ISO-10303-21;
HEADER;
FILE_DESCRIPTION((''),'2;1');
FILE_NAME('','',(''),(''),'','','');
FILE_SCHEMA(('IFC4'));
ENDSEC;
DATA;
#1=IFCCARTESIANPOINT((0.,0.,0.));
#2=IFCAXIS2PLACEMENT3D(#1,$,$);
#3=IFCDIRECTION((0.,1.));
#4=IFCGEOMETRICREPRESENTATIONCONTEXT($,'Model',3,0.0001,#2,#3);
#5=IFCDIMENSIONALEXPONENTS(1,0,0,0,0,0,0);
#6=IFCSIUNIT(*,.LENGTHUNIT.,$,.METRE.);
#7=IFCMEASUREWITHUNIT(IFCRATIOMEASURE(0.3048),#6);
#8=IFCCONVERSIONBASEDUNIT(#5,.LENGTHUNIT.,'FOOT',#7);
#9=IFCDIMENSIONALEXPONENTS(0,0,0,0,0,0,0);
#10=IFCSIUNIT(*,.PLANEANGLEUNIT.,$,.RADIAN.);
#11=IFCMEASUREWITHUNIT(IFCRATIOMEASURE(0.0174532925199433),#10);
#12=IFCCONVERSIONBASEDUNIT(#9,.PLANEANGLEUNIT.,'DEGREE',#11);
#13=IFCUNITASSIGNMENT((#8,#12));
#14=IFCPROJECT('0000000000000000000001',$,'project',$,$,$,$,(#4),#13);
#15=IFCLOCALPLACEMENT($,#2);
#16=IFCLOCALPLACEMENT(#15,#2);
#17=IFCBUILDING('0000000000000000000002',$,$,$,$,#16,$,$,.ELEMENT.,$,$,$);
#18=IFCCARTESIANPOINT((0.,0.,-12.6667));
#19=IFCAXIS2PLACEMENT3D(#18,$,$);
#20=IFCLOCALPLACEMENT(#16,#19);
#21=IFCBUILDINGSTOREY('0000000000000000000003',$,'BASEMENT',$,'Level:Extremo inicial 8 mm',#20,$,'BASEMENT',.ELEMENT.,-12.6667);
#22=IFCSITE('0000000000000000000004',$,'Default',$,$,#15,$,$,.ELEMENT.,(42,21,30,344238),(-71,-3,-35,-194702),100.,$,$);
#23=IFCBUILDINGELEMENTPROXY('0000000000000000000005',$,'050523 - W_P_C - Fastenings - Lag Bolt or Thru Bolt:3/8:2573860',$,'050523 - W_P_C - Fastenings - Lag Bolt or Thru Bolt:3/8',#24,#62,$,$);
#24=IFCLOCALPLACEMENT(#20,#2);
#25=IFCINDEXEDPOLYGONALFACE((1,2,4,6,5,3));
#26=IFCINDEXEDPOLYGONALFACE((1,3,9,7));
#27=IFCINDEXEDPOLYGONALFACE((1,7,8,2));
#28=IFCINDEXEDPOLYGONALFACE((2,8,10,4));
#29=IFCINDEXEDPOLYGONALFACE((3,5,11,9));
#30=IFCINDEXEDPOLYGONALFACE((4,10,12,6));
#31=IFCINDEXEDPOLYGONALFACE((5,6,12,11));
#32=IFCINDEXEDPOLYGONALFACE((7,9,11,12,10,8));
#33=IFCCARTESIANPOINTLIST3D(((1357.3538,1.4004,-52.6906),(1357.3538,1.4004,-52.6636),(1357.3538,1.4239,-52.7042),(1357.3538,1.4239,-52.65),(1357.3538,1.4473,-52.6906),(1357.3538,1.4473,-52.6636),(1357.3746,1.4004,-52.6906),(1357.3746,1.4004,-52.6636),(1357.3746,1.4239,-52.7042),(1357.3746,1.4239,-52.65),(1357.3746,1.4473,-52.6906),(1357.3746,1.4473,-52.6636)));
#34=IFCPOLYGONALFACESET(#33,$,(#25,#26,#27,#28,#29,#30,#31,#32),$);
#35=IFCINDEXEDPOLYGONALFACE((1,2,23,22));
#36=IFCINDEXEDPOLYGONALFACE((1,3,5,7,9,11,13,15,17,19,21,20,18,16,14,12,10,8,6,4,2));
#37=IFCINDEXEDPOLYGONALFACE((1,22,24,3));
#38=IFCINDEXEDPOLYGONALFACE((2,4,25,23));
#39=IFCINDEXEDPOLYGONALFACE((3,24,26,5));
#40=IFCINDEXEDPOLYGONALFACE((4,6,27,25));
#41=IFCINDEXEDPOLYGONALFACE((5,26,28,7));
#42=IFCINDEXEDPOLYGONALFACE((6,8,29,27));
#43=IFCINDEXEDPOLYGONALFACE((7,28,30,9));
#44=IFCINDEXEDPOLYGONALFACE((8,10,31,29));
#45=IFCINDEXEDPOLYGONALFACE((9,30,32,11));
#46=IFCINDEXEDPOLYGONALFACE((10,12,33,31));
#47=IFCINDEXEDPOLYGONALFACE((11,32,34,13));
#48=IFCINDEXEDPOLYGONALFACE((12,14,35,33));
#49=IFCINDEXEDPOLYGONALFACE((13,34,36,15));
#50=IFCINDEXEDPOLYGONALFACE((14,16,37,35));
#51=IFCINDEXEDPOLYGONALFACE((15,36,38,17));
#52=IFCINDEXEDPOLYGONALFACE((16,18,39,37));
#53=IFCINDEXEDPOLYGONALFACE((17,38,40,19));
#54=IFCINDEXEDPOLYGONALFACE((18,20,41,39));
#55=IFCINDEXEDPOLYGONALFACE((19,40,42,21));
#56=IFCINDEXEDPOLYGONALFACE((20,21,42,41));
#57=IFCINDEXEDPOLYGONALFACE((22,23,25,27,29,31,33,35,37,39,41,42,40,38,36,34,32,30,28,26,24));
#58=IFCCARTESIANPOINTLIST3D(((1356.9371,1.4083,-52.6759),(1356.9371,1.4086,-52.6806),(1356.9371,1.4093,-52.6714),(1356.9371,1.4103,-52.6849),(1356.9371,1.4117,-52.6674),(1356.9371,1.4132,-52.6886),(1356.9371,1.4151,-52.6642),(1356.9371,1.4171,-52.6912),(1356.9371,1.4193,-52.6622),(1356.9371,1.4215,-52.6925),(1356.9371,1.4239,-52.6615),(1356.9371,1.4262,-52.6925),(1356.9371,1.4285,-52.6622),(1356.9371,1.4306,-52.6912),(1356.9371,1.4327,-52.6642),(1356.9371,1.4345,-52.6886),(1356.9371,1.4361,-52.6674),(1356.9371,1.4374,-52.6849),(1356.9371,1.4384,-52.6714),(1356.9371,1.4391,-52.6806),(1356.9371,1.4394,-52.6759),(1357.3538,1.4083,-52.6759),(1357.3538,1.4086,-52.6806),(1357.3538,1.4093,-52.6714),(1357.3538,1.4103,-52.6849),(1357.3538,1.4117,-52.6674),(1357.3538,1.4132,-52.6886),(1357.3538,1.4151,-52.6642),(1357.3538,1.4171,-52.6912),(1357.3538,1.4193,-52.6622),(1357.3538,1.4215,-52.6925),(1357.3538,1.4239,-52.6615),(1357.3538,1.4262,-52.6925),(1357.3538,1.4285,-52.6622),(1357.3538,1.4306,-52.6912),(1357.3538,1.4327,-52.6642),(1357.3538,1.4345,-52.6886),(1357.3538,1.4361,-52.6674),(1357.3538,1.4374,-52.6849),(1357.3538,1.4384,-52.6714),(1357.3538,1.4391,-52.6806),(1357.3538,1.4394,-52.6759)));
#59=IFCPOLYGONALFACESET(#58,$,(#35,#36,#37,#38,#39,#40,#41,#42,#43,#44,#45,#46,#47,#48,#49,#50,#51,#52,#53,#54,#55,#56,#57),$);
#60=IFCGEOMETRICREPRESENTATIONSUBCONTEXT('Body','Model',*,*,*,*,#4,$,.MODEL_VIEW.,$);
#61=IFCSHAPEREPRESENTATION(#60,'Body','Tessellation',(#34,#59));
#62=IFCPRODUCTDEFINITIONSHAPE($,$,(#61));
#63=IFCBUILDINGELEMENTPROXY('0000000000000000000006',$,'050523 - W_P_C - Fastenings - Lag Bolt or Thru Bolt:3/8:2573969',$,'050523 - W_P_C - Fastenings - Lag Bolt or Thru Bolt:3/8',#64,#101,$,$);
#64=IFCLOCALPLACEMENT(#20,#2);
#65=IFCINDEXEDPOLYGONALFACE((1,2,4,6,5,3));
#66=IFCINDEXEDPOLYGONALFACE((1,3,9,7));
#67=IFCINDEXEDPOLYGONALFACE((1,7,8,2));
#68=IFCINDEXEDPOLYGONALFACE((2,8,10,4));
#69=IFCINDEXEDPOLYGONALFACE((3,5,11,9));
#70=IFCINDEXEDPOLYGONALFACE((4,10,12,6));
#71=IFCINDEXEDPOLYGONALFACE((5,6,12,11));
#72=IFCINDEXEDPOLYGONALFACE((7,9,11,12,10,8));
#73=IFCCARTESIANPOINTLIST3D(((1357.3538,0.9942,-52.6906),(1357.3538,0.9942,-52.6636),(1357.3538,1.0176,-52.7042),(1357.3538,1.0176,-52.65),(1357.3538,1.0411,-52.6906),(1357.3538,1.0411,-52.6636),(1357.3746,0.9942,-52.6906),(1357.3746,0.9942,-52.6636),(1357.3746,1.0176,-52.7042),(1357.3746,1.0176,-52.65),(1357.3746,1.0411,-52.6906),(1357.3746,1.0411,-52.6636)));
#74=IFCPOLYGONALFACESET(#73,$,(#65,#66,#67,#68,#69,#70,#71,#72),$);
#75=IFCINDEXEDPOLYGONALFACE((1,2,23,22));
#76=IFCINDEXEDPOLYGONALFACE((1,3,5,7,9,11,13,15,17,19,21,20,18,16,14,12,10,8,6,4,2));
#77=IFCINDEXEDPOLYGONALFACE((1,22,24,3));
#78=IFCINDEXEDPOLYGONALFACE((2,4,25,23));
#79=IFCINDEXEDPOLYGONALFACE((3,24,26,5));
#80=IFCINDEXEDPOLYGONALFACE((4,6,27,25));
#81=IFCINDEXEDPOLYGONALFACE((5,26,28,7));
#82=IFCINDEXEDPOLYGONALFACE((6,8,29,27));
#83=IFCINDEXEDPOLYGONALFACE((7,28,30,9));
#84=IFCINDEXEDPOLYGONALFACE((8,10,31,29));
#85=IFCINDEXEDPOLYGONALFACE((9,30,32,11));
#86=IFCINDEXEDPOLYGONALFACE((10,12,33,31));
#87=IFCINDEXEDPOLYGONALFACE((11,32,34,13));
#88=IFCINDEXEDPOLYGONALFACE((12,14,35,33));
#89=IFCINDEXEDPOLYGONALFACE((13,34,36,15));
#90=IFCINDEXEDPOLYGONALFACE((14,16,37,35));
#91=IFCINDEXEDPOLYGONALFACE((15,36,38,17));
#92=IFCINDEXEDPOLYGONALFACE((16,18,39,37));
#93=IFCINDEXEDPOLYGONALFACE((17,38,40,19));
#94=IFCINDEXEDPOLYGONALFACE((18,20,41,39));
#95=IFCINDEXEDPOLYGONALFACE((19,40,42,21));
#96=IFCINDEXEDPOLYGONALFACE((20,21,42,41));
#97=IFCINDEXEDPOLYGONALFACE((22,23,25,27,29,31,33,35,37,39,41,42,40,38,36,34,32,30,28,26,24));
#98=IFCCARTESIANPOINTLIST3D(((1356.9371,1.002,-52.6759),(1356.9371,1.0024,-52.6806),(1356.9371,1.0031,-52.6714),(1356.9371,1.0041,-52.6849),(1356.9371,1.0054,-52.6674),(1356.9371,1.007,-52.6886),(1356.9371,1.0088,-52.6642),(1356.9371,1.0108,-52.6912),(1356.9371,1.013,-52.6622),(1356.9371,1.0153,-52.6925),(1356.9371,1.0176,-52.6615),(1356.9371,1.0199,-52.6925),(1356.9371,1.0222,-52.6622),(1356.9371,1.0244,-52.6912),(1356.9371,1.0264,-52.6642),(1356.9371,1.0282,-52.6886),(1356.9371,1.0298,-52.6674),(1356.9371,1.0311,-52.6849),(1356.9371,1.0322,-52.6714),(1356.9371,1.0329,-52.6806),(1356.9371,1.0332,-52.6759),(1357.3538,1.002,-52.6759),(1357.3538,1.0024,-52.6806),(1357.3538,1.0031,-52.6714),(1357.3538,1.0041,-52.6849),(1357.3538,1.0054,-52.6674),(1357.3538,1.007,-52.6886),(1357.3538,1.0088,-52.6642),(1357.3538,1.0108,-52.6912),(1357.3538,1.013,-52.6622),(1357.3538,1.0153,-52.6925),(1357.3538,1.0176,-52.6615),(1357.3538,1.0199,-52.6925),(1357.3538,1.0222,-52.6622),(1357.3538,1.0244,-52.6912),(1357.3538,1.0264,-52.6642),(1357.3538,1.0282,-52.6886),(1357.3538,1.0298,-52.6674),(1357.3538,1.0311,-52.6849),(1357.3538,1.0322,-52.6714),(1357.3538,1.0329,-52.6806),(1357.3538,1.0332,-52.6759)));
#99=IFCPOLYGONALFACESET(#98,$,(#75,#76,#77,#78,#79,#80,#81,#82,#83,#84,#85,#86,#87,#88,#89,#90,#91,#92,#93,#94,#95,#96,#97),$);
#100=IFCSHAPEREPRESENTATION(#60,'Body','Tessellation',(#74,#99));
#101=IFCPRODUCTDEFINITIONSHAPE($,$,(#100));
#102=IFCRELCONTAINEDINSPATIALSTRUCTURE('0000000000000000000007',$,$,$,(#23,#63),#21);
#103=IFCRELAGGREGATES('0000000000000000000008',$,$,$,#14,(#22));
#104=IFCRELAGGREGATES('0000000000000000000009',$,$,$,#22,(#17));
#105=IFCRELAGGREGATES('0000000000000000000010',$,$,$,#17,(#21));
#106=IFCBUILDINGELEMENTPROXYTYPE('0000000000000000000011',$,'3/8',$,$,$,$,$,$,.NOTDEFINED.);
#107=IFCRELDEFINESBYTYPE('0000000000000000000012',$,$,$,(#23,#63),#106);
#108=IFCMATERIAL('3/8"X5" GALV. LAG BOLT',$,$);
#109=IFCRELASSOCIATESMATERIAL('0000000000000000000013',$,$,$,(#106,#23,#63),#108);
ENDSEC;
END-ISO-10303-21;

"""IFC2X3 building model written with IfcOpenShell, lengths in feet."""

from ifc_helpers import new_model, entity, si_unit, converted_unit, direction, frame, frame_2d, origin, place, context, subcontext, project, spatial, polyline, circle, outline, extrude, source, transform, mapped, material, type_object, type_shapes, element, save


model = new_model("IFC2X3")

# Units and contexts
model_context = context("Model", 3, precision=0.0001, world=origin(), true_north=direction((0.0, 1.0)))
body_context = subcontext(model_context, "Body", "Model", "MODEL_VIEW")
ifc_project = project(units=[converted_unit("LENGTHUNIT", "FOOT", entity("IfcRatioMeasure", 0.3048), si_unit("LENGTHUNIT", "METRE"), dimensions=[1, 0, 0, 0, 0, 0, 0]), converted_unit("PLANEANGLEUNIT", "DEGREE", entity("IfcRatioMeasure", 0.0174532925199433), si_unit("PLANEANGLEUNIT", "RADIAN"), dimensions=[0, 0, 0, 0, 0, 0, 0])], contexts=[model_context])

# Site, building, storey
site_placement = place(None, origin())
site = spatial("IfcSite", under=ifc_project, at=site_placement, Name="Default", CompositionType="ELEMENT", RefLatitude=(42, 21, 30, 344238), RefLongitude=(-71, -3, -35, -194702), RefElevation=100.0)
building_placement = place(site_placement, origin())
building = spatial("IfcBuilding", under=site, at=building_placement, CompositionType="ELEMENT")
storey_placement = place(building_placement, frame((0.0, 0.0, -12.6667)))
storey = spatial("IfcBuildingStorey", under=building, at=storey_placement, Name="BASEMENT", ObjectType="Level:Extremo inicial 8 mm", LongName="BASEMENT", CompositionType="ELEMENT", Elevation=-12.6667)

# Building element proxies
ifc_material_1 = material(Name="3/8\"X5\" GALV. LAG BOLT")
building_element_proxy_type = type_object("IfcBuildingElementProxyType", Name="3/8", PredefinedType="NOTDEFINED", material=ifc_material_1)
shared_shape = source(origin(), body_context, "Body", "SweptSolid", [
    extrude(outline(polyline([(-0.0135, -0.0234), (0.0135, -0.0234), (0.0271, 0.0), (0.0135, 0.0234), (-0.0135, 0.0234), (-0.0271, 0.0), (-0.0135, -0.0234)])), frame((0.0, 0.0, 0.0), z_axis=(0.0, 0.0, 1.0), x_axis=(0.0, -1.0, 0.0)), (0.0, 0.0, 1.0), 0.0208),
    extrude(circle(Radius=0.0156, at=frame_2d((0.0, 0.0), x_axis=(1.0, 0.0))), frame((0.0, 0.0, -0.4167), z_axis=(0.0, 0.0, 1.0), x_axis=(0.0, 1.0, 0.0)), (0.0, 0.0, 1.0), 0.4167),
])
type_shapes(building_element_proxy_type, [shared_shape])
for number, where, z_axis, x_axis, name in (
    (1, (1357.3538, 1.4239, -52.6771), (1.0, 0.0, 0.0), (0.0, 1.0, 0.0), "050523 - W_P_C - Fastenings - Lag Bolt or Thru Bolt:3/8:2573860"),
    (2, (1357.3538, 1.0176, -52.6771), (1.0, 0.0, 0.0), (0.0, 1.0, 0.0), "050523 - W_P_C - Fastenings - Lag Bolt or Thru Bolt:3/8:2573969"),
):
    element("IfcBuildingElementProxy", number, at=place(storey_placement, frame(where, z_axis=z_axis, x_axis=x_axis)), inside=storey, type_object=building_element_proxy_type, material=ifc_material_1, Name=name, ObjectType="050523 - W_P_C - Fastenings - Lag Bolt or Thru Bolt:3/8", context=body_context, shape_type="MappedRepresentation", body=[
        mapped(shared_shape, transform((0.0, 0.0, 0.0), scale=1.0)),
    ])

save(model, "model.ifc")
